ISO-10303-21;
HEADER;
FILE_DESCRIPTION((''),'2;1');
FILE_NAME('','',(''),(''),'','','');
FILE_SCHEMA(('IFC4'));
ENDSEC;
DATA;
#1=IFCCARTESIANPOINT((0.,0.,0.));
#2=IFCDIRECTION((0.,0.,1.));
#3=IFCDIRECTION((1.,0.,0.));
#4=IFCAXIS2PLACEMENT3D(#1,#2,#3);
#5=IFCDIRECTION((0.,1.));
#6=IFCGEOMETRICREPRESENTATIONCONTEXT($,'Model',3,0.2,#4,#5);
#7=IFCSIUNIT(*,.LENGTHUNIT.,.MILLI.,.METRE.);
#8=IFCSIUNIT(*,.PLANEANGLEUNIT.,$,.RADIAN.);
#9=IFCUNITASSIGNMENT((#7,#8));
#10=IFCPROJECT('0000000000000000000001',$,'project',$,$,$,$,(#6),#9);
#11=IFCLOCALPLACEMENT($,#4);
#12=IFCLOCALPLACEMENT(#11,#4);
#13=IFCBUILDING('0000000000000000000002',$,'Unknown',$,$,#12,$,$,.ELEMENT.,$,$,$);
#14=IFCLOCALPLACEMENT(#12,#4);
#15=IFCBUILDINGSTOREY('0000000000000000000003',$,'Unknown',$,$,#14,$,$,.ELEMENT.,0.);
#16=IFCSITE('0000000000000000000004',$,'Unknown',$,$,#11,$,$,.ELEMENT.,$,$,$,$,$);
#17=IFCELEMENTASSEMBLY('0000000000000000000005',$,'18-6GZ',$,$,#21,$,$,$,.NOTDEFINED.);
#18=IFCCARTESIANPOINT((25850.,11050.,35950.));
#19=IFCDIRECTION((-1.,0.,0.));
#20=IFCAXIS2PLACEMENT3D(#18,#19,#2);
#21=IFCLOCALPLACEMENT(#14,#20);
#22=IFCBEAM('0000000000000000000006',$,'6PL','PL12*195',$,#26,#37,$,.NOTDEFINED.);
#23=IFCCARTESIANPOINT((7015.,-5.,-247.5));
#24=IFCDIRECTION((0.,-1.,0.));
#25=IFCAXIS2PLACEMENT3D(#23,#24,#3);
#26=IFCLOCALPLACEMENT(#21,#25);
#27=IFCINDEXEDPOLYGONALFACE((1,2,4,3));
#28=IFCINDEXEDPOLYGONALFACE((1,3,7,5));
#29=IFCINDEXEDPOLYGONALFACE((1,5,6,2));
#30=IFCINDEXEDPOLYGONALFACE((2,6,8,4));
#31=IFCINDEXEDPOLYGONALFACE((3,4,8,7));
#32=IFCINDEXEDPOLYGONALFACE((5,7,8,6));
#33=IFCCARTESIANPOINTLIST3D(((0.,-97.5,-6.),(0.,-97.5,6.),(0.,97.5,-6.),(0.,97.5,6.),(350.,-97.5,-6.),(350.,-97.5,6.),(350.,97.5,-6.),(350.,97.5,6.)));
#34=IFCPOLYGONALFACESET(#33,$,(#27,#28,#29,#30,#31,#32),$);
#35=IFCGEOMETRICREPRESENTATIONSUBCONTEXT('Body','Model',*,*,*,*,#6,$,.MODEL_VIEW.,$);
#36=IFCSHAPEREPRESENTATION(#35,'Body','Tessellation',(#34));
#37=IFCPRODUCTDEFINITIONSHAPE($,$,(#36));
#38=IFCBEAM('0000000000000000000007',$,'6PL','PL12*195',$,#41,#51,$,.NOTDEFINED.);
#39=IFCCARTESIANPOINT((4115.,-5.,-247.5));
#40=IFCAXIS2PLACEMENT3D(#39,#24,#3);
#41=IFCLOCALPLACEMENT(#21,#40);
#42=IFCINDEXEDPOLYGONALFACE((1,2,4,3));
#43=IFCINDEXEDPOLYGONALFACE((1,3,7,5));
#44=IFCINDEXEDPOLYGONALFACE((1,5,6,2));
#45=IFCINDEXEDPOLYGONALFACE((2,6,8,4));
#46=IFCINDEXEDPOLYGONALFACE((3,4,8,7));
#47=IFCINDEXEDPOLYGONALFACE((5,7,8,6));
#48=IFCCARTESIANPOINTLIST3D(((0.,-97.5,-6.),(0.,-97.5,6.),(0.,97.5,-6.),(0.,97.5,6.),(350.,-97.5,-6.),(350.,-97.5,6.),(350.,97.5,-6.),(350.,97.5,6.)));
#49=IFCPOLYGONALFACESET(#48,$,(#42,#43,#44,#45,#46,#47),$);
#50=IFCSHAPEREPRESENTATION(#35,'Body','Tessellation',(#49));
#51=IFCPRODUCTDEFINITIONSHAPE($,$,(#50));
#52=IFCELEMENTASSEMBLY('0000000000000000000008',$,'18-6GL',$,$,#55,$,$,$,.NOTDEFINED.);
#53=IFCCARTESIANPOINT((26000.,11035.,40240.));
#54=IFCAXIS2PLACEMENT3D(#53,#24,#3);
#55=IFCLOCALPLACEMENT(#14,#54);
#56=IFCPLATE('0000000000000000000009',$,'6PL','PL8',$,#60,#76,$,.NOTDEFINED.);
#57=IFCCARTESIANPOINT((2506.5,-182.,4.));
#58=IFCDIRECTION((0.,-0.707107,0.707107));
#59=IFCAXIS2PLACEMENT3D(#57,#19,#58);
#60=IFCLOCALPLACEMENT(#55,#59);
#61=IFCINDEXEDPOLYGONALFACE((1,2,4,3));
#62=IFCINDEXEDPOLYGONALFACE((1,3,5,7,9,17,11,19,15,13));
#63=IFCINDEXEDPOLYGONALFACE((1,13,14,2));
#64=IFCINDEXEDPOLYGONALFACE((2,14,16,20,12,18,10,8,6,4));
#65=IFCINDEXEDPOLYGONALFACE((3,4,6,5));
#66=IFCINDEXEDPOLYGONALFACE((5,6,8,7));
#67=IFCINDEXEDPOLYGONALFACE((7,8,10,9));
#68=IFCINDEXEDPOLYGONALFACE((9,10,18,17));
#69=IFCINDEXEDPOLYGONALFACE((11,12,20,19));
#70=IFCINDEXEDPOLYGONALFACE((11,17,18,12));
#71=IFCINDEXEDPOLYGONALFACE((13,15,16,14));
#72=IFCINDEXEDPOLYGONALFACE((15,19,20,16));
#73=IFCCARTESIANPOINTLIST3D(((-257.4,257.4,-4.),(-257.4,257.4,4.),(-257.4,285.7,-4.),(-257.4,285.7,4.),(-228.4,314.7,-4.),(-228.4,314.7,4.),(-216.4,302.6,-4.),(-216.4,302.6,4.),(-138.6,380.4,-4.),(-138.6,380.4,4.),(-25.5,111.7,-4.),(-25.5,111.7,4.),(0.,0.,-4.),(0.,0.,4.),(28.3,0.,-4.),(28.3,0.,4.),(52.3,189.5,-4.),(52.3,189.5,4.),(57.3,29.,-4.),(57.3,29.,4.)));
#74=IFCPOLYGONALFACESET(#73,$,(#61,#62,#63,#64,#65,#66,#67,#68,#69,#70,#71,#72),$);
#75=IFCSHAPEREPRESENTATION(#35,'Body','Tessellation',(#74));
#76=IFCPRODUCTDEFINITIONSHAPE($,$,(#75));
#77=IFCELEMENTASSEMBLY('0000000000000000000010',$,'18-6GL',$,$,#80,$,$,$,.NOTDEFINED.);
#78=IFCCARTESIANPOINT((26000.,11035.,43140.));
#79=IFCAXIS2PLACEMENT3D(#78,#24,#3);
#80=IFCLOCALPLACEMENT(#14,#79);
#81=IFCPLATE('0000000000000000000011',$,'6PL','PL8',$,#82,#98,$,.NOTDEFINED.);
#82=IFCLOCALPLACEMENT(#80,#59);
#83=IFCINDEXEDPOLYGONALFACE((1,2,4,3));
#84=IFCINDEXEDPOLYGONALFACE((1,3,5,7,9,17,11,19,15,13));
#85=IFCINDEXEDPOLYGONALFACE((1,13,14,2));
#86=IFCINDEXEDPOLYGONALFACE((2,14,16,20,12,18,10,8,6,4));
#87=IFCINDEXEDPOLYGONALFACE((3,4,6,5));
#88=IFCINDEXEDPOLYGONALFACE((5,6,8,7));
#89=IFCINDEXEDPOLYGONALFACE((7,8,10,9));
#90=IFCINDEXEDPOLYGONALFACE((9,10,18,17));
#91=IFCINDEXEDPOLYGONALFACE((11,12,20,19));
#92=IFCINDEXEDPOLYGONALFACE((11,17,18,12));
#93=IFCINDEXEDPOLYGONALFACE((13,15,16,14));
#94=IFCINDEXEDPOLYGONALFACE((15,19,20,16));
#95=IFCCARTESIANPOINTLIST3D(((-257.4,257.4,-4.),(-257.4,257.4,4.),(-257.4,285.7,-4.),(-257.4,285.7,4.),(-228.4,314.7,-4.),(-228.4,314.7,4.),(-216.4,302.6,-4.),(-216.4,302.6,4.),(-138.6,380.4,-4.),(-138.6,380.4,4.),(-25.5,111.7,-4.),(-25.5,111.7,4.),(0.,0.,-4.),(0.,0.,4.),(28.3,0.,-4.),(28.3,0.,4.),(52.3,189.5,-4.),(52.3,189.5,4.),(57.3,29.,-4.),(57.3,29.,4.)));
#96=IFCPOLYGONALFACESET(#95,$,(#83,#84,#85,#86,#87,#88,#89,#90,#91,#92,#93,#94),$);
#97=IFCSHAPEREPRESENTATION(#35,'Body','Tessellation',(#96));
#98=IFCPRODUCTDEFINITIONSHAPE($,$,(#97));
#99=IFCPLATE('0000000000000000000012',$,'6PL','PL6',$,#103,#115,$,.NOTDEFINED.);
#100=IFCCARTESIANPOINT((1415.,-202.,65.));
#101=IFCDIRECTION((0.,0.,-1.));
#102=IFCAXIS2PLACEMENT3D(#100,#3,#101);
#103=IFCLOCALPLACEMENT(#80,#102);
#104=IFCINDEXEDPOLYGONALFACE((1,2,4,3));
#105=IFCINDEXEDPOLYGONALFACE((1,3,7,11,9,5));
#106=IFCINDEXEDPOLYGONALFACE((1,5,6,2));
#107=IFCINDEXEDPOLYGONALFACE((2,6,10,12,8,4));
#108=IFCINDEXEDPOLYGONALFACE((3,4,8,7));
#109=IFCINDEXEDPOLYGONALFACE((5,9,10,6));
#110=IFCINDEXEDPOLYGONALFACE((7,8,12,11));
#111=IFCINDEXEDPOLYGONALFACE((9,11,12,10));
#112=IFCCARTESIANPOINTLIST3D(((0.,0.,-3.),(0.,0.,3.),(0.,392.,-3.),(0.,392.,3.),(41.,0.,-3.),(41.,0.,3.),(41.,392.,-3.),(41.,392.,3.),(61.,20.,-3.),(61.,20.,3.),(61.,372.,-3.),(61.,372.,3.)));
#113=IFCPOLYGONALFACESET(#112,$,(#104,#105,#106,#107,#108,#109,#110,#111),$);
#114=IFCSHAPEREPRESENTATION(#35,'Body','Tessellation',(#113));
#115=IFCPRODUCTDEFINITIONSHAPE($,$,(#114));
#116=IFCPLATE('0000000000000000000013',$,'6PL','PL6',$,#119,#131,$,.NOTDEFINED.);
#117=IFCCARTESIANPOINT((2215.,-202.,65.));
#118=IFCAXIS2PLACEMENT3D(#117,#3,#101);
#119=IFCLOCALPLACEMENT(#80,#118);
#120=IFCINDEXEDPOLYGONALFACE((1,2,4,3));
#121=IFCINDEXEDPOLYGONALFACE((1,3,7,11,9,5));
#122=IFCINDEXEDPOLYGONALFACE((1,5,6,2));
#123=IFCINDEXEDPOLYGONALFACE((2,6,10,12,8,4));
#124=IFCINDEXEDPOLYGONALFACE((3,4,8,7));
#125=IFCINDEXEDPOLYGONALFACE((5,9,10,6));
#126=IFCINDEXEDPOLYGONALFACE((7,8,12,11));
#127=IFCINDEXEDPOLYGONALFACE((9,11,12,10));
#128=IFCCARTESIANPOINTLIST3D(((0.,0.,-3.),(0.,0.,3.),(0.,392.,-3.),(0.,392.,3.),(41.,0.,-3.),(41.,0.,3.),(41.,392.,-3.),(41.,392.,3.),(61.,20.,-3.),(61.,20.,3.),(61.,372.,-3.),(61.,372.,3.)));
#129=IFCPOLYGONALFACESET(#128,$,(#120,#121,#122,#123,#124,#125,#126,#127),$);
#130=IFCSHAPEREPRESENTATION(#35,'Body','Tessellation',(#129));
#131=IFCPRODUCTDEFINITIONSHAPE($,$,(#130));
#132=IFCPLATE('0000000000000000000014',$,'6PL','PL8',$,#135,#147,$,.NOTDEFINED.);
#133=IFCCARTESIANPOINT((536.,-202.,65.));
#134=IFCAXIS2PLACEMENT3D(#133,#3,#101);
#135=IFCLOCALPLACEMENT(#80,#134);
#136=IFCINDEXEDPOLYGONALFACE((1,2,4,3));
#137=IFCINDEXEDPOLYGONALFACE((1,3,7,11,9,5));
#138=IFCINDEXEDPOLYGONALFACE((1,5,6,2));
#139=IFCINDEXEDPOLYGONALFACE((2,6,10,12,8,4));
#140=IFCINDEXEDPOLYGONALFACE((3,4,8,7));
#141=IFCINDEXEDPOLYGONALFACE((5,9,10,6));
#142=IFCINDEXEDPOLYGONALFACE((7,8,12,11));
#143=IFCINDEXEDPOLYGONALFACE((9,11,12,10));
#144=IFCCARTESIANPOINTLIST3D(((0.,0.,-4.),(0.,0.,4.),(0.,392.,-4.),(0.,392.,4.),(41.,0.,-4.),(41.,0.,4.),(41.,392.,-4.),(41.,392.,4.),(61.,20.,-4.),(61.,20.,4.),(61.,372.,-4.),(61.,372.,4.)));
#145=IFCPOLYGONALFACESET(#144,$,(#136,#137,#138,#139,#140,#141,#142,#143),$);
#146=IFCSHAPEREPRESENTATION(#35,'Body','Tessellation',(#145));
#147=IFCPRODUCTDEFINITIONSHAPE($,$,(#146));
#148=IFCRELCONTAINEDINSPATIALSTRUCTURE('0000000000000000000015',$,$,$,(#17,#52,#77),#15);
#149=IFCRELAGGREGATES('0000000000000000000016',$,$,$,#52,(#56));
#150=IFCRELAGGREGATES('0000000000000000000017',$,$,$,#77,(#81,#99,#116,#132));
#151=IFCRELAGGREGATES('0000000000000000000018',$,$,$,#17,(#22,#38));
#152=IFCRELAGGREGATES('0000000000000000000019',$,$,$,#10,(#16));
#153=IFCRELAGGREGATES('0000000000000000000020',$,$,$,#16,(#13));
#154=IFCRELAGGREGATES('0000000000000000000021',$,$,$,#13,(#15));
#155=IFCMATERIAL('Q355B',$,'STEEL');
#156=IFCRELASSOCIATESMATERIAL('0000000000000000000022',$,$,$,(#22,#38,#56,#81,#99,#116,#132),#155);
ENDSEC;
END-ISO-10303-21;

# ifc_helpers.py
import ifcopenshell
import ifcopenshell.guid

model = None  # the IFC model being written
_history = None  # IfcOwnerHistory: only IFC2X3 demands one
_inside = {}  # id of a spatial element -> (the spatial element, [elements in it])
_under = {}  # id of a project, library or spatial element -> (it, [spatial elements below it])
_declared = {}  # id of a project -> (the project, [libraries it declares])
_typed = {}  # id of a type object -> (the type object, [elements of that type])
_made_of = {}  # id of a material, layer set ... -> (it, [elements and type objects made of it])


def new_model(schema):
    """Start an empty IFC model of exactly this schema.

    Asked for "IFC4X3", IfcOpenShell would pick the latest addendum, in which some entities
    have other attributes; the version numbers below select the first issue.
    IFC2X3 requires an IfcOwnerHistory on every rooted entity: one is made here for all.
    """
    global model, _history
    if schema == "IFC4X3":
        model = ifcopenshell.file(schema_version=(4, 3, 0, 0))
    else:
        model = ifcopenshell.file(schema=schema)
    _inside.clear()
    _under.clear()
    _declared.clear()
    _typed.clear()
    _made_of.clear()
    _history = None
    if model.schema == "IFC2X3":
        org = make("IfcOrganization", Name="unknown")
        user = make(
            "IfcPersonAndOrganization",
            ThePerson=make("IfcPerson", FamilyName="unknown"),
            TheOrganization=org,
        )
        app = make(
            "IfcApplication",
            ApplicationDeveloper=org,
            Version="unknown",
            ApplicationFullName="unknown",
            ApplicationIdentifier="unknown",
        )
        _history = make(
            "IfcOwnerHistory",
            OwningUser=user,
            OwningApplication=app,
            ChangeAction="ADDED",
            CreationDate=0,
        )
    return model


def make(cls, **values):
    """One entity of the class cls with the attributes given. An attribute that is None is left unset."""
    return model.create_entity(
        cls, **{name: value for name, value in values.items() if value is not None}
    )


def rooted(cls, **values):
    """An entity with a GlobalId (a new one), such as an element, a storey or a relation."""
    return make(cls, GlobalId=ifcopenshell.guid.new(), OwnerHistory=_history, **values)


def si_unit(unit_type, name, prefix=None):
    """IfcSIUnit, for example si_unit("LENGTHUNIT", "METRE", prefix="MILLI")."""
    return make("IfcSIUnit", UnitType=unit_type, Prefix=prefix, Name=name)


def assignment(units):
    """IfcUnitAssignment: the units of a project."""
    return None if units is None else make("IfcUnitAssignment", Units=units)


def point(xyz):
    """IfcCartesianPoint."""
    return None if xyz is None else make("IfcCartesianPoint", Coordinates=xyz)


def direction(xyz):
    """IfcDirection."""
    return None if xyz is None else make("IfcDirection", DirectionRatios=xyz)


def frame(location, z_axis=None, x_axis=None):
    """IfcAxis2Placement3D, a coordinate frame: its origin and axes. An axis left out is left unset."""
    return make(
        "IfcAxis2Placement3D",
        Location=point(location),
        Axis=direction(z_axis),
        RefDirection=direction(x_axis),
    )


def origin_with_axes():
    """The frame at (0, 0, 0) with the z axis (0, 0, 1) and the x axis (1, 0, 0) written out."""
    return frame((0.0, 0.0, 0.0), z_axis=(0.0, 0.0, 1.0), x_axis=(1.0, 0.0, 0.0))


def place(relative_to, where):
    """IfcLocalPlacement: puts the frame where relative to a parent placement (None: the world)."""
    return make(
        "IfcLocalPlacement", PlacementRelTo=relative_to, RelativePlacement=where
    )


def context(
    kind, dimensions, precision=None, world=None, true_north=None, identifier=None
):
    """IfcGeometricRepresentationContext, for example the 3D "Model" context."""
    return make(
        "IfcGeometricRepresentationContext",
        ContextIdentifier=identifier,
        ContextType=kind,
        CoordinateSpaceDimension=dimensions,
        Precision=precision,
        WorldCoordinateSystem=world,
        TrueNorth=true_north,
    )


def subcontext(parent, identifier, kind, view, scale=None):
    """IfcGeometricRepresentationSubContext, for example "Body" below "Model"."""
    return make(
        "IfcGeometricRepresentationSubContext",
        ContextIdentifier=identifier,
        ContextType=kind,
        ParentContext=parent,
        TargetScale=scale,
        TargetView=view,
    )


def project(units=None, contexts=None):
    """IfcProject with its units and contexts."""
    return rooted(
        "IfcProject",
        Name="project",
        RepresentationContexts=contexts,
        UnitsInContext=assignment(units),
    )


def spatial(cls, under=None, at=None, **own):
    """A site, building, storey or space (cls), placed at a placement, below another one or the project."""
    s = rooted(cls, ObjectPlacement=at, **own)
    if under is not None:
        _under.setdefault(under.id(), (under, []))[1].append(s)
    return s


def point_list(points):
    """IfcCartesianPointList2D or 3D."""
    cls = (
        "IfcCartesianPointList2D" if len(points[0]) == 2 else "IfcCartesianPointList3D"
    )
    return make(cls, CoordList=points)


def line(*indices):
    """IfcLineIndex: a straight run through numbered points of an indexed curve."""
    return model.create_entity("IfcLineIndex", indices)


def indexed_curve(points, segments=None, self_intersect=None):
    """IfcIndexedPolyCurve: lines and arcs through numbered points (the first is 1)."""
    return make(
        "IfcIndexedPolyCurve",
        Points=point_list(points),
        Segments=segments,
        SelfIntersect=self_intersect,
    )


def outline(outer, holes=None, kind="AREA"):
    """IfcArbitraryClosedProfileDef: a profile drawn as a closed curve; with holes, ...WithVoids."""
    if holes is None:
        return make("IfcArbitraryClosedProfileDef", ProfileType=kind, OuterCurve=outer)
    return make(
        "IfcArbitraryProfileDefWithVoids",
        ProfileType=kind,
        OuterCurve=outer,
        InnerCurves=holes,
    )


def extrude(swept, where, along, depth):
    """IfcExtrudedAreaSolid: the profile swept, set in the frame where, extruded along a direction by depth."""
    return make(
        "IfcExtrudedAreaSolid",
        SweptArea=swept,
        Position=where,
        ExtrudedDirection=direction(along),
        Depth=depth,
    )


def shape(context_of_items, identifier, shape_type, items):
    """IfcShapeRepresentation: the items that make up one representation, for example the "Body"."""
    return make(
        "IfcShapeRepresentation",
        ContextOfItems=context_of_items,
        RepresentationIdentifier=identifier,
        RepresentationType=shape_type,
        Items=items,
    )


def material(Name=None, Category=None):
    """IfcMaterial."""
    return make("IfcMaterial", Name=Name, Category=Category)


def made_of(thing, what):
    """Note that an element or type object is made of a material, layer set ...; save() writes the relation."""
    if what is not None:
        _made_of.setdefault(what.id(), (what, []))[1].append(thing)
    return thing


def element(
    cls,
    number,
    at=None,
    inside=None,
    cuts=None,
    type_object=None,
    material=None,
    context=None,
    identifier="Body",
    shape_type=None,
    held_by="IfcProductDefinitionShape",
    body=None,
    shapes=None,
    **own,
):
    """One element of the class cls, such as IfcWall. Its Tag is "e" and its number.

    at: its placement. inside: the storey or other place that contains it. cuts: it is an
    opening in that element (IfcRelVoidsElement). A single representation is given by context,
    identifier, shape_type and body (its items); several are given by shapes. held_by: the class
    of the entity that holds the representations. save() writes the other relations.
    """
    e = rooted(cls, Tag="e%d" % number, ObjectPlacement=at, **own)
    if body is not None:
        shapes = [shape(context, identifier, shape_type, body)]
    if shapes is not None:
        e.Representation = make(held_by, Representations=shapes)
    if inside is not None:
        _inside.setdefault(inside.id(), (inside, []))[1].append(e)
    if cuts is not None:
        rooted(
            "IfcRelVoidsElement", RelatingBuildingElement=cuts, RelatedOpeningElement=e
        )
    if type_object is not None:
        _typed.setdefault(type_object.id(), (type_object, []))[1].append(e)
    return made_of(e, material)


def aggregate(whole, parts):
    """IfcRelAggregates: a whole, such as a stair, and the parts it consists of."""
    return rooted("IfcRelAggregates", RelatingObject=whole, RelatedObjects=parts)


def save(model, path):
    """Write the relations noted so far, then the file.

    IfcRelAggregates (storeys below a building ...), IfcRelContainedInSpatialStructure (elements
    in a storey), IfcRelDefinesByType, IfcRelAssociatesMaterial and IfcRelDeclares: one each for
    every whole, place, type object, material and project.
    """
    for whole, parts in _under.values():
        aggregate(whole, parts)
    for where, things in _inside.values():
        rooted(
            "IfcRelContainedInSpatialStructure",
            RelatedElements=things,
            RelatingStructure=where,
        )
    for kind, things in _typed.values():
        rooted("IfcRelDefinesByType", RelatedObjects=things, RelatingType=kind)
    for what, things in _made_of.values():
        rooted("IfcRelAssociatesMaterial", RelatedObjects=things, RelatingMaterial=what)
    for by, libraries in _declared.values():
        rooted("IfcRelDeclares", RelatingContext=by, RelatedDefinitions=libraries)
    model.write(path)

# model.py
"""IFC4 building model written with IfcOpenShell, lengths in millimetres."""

from ifc_helpers import new_model, si_unit, direction, frame, origin_with_axes, place, context, subcontext, project, spatial, line, indexed_curve, outline, extrude, material, element, aggregate, save


model = new_model("IFC4")

# Units and contexts
model_context = context("Model", 3, precision=0.2, world=origin_with_axes(), true_north=direction((0.0, 1.0)))
body_context = subcontext(model_context, "Body", "Model", "MODEL_VIEW")
ifc_project = project(units=[si_unit("LENGTHUNIT", "METRE", prefix="MILLI"), si_unit("PLANEANGLEUNIT", "RADIAN")], contexts=[model_context])

# Site, building, storey
site_placement = place(None, origin_with_axes())
site = spatial("IfcSite", under=ifc_project, at=site_placement, Name="Unknown", CompositionType="ELEMENT")
building_placement = place(site_placement, origin_with_axes())
building = spatial("IfcBuilding", under=site, at=building_placement, Name="Unknown", CompositionType="ELEMENT")
storey_placement = place(building_placement, origin_with_axes())
storey = spatial("IfcBuildingStorey", under=building, at=storey_placement, Name="Unknown", CompositionType="ELEMENT", Elevation=0.0)

# Element assembly, beams
assembly_1_placement = place(storey_placement, frame((25850.0, 11050.0, 35950.0), z_axis=(-1.0, 0.0, 0.0), x_axis=(0.0, 0.0, 1.0)))
assembly_1 = element("IfcElementAssembly", 1, at=assembly_1_placement, inside=storey, Name="18-6GZ", PredefinedType="NOTDEFINED")
ifc_material = material(Name="Q355B", Category="STEEL")
beam_1_placement = place(assembly_1_placement, frame((7015.0, -5.0, -247.5), z_axis=(0.0, -1.0, 0.0), x_axis=(1.0, 0.0, 0.0)))
beam_1 = element("IfcBeam", 2, at=beam_1_placement, material=ifc_material, Name="6PL", Description="PL12*195", PredefinedType="NOTDEFINED", context=body_context, shape_type="SolidModel", body=[
    extrude(outline(indexed_curve([(-6.0, -97.5), (6.0, -97.5), (6.0, 97.5), (-6.0, 97.5)], segments=[line(1, 2, 3, 4, 1)])), frame((0.0, 0.0, 0.0), z_axis=(-1.0, 0.0, 0.0), x_axis=(0.0, 0.0, 1.0)), (0.0, 0.0, -1.0), 350.0),
])
beam_2_placement = place(assembly_1_placement, frame((4115.0, -5.0, -247.5), z_axis=(0.0, -1.0, 0.0), x_axis=(1.0, 0.0, 0.0)))
beam_2 = element("IfcBeam", 3, at=beam_2_placement, material=ifc_material, Name="6PL", Description="PL12*195", PredefinedType="NOTDEFINED", context=body_context, shape_type="SolidModel", body=[
    extrude(outline(indexed_curve([(-6.0, -97.5), (6.0, -97.5), (6.0, 97.5), (-6.0, 97.5)], segments=[line(1, 2, 3, 4, 1)])), frame((0.0, 0.0, 0.0), z_axis=(-1.0, 0.0, 0.0), x_axis=(0.0, 0.0, 1.0)), (0.0, 0.0, -1.0), 350.0),
])

# Element assemblies, plates
assembly_2_placement = place(storey_placement, frame((26000.0, 11035.0, 40240.0), z_axis=(0.0, -1.0, 0.0), x_axis=(1.0, 0.0, 0.0)))
assembly_2 = element("IfcElementAssembly", 4, at=assembly_2_placement, inside=storey, Name="18-6GL", PredefinedType="NOTDEFINED")
plate_1_placement = place(assembly_2_placement, frame((2506.5, -182.0, 4.0), z_axis=(-1.0, 0.0, 0.0), x_axis=(0.0, -0.707107, 0.707107)))
plate_1 = element("IfcPlate", 5, at=plate_1_placement, material=ifc_material, Name="6PL", Description="PL8", PredefinedType="NOTDEFINED", context=body_context, shape_type="SolidModel", body=[
    extrude(outline(indexed_curve([(0.0, 0.0), (28.3, 0.0), (57.3, 29.0), (-25.5, 111.7), (52.3, 189.5), (-138.6, 380.4), (-216.4, 302.6), (-228.4, 314.7), (-257.4, 285.7), (-257.4, 257.4)], segments=[line(1, 2, 3, 4, 5, 6, 7, 8, 9, 10, 1)])), frame((0.0, 0.0, 4.0), z_axis=(0.0, 0.0, 1.0), x_axis=(1.0, 0.0, 0.0)), (0.0, 0.0, -1.0), 8.0),
])
aggregate(assembly_2, [plate_1])
assembly_3_placement = place(storey_placement, frame((26000.0, 11035.0, 43140.0), z_axis=(0.0, -1.0, 0.0), x_axis=(1.0, 0.0, 0.0)))
assembly_3 = element("IfcElementAssembly", 6, at=assembly_3_placement, inside=storey, Name="18-6GL", PredefinedType="NOTDEFINED")
plate_2_placement = place(assembly_3_placement, frame((2506.5, -182.0, 4.0), z_axis=(-1.0, 0.0, 0.0), x_axis=(0.0, -0.707107, 0.707107)))
plate_2 = element("IfcPlate", 7, at=plate_2_placement, material=ifc_material, Name="6PL", Description="PL8", PredefinedType="NOTDEFINED", context=body_context, shape_type="SolidModel", body=[
    extrude(outline(indexed_curve([(0.0, 0.0), (28.3, 0.0), (57.3, 29.0), (-25.5, 111.7), (52.3, 189.5), (-138.6, 380.4), (-216.4, 302.6), (-228.4, 314.7), (-257.4, 285.7), (-257.4, 257.4)], segments=[line(1, 2, 3, 4, 5, 6, 7, 8, 9, 10, 1)])), frame((0.0, 0.0, 4.0), z_axis=(0.0, 0.0, 1.0), x_axis=(1.0, 0.0, 0.0)), (0.0, 0.0, -1.0), 8.0),
])
plate_3_placement = place(assembly_3_placement, frame((1415.0, -202.0, 65.0), z_axis=(1.0, 0.0, 0.0), x_axis=(0.0, 0.0, -1.0)))
plate_3 = element("IfcPlate", 8, at=plate_3_placement, material=ifc_material, Name="6PL", Description="PL6", PredefinedType="NOTDEFINED", context=body_context, shape_type="SolidModel", body=[
    extrude(outline(indexed_curve([(0.0, 0.0), (41.0, 0.0), (61.0, 20.0), (61.0, 372.0), (41.0, 392.0), (0.0, 392.0)], segments=[line(1, 2, 3, 4, 5, 6, 1)])), frame((0.0, 0.0, 3.0), z_axis=(0.0, 0.0, 1.0), x_axis=(1.0, 0.0, 0.0)), (0.0, 0.0, -1.0), 6.0),
])
plate_4_placement = place(assembly_3_placement, frame((2215.0, -202.0, 65.0), z_axis=(1.0, 0.0, 0.0), x_axis=(0.0, 0.0, -1.0)))
plate_4 = element("IfcPlate", 9, at=plate_4_placement, material=ifc_material, Name="6PL", Description="PL6", PredefinedType="NOTDEFINED", context=body_context, shape_type="SolidModel", body=[
    extrude(outline(indexed_curve([(0.0, 0.0), (41.0, 0.0), (61.0, 20.0), (61.0, 372.0), (41.0, 392.0), (0.0, 392.0)], segments=[line(1, 2, 3, 4, 5, 6, 1)])), frame((0.0, 0.0, 3.0), z_axis=(0.0, 0.0, 1.0), x_axis=(1.0, 0.0, 0.0)), (0.0, 0.0, -1.0), 6.0),
])
plate_5_placement = place(assembly_3_placement, frame((536.0, -202.0, 65.0), z_axis=(1.0, 0.0, 0.0), x_axis=(0.0, 0.0, -1.0)))
plate_5 = element("IfcPlate", 10, at=plate_5_placement, material=ifc_material, Name="6PL", Description="PL8", PredefinedType="NOTDEFINED", context=body_context, shape_type="SolidModel", body=[
    extrude(outline(indexed_curve([(0.0, 0.0), (41.0, 0.0), (61.0, 20.0), (61.0, 372.0), (41.0, 392.0), (0.0, 392.0)], segments=[line(1, 2, 3, 4, 5, 6, 1)])), frame((0.0, 0.0, 4.0), z_axis=(0.0, 0.0, 1.0), x_axis=(1.0, 0.0, 0.0)), (0.0, 0.0, -1.0), 8.0),
])
aggregate(assembly_3, [plate_2, plate_3, plate_4, plate_5])

aggregate(assembly_1, [beam_1, beam_2])

save(model, "model.ifc")
